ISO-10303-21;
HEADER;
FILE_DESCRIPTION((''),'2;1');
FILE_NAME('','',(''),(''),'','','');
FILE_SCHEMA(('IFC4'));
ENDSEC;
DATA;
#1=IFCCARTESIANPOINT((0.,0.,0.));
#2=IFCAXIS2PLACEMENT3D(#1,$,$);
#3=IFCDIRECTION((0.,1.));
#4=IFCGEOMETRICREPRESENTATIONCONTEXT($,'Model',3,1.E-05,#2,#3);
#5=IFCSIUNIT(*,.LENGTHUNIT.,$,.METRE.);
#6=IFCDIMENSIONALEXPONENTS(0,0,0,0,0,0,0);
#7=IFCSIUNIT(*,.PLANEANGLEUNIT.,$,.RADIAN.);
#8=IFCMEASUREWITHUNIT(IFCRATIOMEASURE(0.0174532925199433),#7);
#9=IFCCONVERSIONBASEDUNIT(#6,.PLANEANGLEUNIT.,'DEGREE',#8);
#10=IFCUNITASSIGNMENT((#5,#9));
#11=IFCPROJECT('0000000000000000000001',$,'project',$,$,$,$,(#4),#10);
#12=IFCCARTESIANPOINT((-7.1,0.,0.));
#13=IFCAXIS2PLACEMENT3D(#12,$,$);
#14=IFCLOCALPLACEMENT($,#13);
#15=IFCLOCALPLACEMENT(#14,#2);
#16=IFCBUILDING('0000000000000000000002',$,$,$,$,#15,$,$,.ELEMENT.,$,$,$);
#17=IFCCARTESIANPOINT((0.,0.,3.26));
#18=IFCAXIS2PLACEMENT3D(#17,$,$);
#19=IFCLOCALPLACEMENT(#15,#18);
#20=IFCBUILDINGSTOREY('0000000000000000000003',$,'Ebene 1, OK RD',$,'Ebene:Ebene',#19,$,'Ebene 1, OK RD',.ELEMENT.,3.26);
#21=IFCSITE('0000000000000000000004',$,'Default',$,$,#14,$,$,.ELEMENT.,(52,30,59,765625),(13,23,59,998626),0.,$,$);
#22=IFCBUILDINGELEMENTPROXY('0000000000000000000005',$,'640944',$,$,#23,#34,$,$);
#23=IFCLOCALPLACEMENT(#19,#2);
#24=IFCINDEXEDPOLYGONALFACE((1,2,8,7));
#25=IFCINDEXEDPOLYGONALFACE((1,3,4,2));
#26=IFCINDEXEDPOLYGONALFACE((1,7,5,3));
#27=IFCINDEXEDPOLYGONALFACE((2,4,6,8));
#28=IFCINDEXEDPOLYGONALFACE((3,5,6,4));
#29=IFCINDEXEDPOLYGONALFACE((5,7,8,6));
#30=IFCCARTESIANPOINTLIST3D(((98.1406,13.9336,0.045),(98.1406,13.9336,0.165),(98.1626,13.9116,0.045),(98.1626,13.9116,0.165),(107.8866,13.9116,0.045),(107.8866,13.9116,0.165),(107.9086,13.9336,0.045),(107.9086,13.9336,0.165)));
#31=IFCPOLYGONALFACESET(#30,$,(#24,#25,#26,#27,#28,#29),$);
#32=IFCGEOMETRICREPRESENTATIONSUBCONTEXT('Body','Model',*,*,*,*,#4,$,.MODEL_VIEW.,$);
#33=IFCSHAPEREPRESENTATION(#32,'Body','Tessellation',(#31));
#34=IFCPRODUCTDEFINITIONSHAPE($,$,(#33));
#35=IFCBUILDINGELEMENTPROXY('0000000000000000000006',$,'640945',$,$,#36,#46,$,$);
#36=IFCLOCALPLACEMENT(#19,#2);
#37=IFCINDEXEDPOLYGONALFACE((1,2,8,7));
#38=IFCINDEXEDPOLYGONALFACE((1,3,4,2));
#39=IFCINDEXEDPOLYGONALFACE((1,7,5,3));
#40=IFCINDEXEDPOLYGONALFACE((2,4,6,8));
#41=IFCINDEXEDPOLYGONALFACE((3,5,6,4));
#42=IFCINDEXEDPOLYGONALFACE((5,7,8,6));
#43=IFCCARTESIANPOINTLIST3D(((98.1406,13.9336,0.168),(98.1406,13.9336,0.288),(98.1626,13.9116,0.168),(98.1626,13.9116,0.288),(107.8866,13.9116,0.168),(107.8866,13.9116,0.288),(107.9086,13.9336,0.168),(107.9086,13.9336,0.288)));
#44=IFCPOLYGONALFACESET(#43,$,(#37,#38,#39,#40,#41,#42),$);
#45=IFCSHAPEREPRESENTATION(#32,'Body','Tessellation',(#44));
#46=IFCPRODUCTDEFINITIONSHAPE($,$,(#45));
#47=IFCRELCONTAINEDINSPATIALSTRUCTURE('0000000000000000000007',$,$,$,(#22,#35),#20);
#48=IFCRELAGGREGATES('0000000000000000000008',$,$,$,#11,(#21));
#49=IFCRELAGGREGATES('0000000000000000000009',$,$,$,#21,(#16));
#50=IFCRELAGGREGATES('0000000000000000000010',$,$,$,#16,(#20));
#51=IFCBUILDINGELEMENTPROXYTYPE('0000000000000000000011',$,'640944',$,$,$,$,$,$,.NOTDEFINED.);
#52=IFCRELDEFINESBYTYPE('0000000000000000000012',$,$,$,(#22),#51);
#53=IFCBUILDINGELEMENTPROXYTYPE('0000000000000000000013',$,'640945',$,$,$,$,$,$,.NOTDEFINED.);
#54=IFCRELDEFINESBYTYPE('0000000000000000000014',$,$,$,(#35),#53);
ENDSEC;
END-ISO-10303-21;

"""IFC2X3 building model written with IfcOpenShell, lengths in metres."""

from ifc_helpers import new_model, entity, si_unit, converted_unit, direction, frame, origin, place, context, subcontext, project, spatial, polyline, outline, extrude, type_object, element, save


model = new_model("IFC2X3")

# Units and contexts
model_context = context("Model", 3, precision=1e-05, world=origin(), true_north=direction((0.0, 1.0)))
body_context = subcontext(model_context, "Body", "Model", "MODEL_VIEW")
ifc_project = project(units=[si_unit("LENGTHUNIT", "METRE"), converted_unit("PLANEANGLEUNIT", "DEGREE", entity("IfcRatioMeasure", 0.0174532925199433), si_unit("PLANEANGLEUNIT", "RADIAN"), dimensions=[0, 0, 0, 0, 0, 0, 0])], contexts=[model_context])

# Site, building, storey
site_placement = place(None, frame((-7.1, 0.0, 0.0)))
site = spatial("IfcSite", under=ifc_project, at=site_placement, Name="Default", CompositionType="ELEMENT", RefLatitude=(52, 30, 59, 765625), RefLongitude=(13, 23, 59, 998626), RefElevation=0.0)
building_placement = place(site_placement, origin())
building = spatial("IfcBuilding", under=site, at=building_placement, CompositionType="ELEMENT")
storey_placement = place(building_placement, frame((0.0, 0.0, 3.26)))
storey = spatial("IfcBuildingStorey", under=building, at=storey_placement, Name="Ebene 1, OK RD", ObjectType="Ebene:Ebene", LongName="Ebene 1, OK RD", CompositionType="ELEMENT", Elevation=3.26)

# Building element proxies
building_element_proxy_type_1 = type_object("IfcBuildingElementProxyType", Name="640944", PredefinedType="NOTDEFINED")
proxy_1_placement = place(storey_placement, origin())
element("IfcBuildingElementProxy", 1, at=proxy_1_placement, inside=storey, type_object=building_element_proxy_type_1, Name="640944", context=body_context, shape_type="SweptSolid", body=[
    extrude(outline(polyline([(-4.862, -0.011), (4.862, -0.011), (4.884, 0.011), (-4.884, 0.011), (-4.862, -0.011)])), frame((103.0246, 13.9226, 0.045)), (0.0, 0.0, 1.0), 0.12),
])
building_element_proxy_type_2 = type_object("IfcBuildingElementProxyType", Name="640945", PredefinedType="NOTDEFINED")
proxy_2_placement = place(storey_placement, origin())
element("IfcBuildingElementProxy", 2, at=proxy_2_placement, inside=storey, type_object=building_element_proxy_type_2, Name="640945", context=body_context, shape_type="SweptSolid", body=[
    extrude(outline(polyline([(-4.862, -0.011), (4.862, -0.011), (4.884, 0.011), (-4.884, 0.011), (-4.862, -0.011)])), frame((103.0246, 13.9226, 0.168)), (0.0, 0.0, 1.0), 0.12),
])

save(model, "model.ifc")
